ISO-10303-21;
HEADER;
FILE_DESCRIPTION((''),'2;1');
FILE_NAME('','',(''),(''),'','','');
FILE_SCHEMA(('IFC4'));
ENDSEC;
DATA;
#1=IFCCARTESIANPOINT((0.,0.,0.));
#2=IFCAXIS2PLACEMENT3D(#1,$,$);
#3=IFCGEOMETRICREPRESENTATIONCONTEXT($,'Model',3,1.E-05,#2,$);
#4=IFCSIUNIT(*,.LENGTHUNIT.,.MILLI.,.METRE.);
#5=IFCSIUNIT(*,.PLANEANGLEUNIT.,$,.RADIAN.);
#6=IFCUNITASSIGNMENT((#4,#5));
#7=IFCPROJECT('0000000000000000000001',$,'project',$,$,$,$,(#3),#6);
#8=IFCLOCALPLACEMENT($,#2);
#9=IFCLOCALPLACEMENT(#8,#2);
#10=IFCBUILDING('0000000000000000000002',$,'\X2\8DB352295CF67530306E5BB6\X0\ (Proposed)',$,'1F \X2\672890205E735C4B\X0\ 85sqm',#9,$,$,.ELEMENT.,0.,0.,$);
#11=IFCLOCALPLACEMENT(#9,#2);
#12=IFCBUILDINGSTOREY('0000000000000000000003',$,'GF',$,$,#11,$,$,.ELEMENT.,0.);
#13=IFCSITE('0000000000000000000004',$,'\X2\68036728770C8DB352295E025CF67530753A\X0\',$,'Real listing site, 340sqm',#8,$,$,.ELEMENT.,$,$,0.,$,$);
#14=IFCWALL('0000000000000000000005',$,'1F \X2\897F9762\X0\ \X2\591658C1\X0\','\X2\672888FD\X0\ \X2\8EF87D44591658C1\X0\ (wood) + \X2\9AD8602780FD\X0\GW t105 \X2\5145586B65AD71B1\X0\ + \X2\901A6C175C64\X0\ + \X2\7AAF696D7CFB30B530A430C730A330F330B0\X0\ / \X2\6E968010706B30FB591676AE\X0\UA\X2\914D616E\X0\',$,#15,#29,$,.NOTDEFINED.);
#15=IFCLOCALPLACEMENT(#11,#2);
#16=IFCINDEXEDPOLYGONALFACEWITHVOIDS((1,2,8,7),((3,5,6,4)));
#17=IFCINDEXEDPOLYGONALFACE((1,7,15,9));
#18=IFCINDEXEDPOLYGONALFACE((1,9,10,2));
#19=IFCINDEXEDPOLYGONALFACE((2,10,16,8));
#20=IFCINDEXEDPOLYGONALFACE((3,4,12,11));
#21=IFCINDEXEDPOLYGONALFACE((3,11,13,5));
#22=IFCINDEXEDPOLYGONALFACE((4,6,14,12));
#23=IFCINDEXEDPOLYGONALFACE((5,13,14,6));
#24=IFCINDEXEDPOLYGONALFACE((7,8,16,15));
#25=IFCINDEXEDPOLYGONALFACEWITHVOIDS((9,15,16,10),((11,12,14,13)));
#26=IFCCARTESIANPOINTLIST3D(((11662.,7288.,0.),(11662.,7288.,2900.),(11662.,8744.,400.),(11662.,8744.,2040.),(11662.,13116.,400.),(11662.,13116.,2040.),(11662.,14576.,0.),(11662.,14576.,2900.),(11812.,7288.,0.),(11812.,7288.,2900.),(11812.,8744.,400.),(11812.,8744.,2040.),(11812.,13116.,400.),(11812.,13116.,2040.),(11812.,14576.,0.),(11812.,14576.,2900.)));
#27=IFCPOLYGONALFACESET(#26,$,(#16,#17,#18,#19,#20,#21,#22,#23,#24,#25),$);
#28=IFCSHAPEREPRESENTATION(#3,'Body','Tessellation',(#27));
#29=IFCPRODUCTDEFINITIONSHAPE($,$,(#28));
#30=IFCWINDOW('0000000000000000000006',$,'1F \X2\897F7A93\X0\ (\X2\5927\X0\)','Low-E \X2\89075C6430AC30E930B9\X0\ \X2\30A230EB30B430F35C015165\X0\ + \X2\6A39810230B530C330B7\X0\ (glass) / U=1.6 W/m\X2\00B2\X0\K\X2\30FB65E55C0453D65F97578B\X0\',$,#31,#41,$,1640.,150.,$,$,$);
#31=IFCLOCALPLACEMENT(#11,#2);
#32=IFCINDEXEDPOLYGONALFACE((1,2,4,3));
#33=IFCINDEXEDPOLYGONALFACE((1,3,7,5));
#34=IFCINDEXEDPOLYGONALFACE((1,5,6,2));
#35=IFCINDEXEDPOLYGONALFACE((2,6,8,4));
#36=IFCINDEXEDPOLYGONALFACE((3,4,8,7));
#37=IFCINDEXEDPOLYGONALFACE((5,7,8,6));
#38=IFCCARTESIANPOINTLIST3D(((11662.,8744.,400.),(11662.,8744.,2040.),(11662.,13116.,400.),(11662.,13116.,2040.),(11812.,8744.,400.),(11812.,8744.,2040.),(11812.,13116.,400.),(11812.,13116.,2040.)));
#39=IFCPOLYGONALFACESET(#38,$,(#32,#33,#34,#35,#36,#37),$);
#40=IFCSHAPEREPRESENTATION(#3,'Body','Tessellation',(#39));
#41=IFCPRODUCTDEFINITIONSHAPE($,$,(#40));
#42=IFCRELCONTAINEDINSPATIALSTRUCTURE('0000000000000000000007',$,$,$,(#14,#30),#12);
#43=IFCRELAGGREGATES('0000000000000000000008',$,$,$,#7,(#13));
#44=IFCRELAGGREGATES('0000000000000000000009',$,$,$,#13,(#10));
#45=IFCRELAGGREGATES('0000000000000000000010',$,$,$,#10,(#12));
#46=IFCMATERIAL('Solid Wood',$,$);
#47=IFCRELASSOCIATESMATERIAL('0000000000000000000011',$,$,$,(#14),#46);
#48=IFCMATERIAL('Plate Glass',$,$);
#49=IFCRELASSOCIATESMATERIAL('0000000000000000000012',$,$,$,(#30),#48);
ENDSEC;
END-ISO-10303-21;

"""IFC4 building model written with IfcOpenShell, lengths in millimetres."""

from ifc_helpers import new_model, si_unit, frame, frame_2d, origin, place, context, project, spatial, rectangle, extrude, material, element, fill, save


model = new_model("IFC4")

# Units and contexts
model_context = context("Model", 3, precision=1e-05, world=origin())
ifc_project = project(units=[si_unit("LENGTHUNIT", "METRE", prefix="MILLI"), si_unit("PLANEANGLEUNIT", "RADIAN")], contexts=[model_context])

# Site, building, storey
site_placement = place(None, origin())
site = spatial("IfcSite", under=ifc_project, at=site_placement, Name="栃木県足利市島田町", ObjectType="Real listing site, 340sqm", CompositionType="ELEMENT", RefElevation=0.0)
building_placement = place(site_placement, origin())
building = spatial("IfcBuilding", under=site, at=building_placement, Name="足利島田の家 (Proposed)", ObjectType="1F 木造平屋 85sqm", CompositionType="ELEMENT", ElevationOfRefHeight=0.0, ElevationOfTerrain=0.0)
storey_placement = place(building_placement, origin())
storey = spatial("IfcBuildingStorey", under=building, at=storey_placement, Name="GF", CompositionType="ELEMENT", Elevation=0.0)

# Shared definitions
ifc_material_1 = material(Name="Solid Wood")

# Shared definitions
ifc_material_2 = material(Name="Plate Glass")

# Wall, opening, window
wall_1_placement = place(storey_placement, frame((5831.0, 3644.0, 0.0)))
wall_1 = element("IfcWall", 1, at=wall_1_placement, inside=storey, material=ifc_material_1, Name="1F 西面 外壁", Description="木製 軸組外壁 (wood) + 高性能GW t105 充填断熱 + 通気層 + 窯業系サイディング / 準耐火・外皮UA配慮", PredefinedType="NOTDEFINED", context=model_context, shape_type="SweptSolid", body=[
    extrude(rectangle(XDim=150.0, YDim=7288.0, at=frame_2d((75.0, 3644.0))), frame((5831.0, 3644.0, 0.0)), (0.0, 0.0, 1.0), 2900.0),
])
opening_1_placement = place(storey_placement, frame((5831.0, 4372.0, 200.0)))
opening_1 = element("IfcOpeningElement", 2, at=opening_1_placement, cuts=wall_1, PredefinedType="NOTDEFINED", context=model_context, shape_type="SweptSolid", body=[
    extrude(rectangle(XDim=150.0, YDim=4372.0, at=frame_2d((75.0, 2186.0))), frame((5831.0, 4372.0, 200.0)), (0.0, 0.0, 1.0), 1640.0),
])
window_1_placement = place(storey_placement, frame((5831.0, 4372.0, 200.0)))
window_1 = element("IfcWindow", 3, at=window_1_placement, inside=storey, material=ifc_material_2, Name="1F 西窓 (大)", Description="Low-E 複層ガラス アルゴン封入 + 樹脂サッシ (glass) / U=1.6 W/m²K・日射取得型", OverallHeight=1640.0, OverallWidth=150.0, context=model_context, shape_type="SweptSolid", body=[
    extrude(rectangle(XDim=150.0, YDim=4372.0, at=frame_2d((75.0, 2186.0))), frame((5831.0, 4372.0, 200.0)), (0.0, 0.0, 1.0), 1640.0),
])
fill(opening_1, window_1)

save(model, "model.ifc")
